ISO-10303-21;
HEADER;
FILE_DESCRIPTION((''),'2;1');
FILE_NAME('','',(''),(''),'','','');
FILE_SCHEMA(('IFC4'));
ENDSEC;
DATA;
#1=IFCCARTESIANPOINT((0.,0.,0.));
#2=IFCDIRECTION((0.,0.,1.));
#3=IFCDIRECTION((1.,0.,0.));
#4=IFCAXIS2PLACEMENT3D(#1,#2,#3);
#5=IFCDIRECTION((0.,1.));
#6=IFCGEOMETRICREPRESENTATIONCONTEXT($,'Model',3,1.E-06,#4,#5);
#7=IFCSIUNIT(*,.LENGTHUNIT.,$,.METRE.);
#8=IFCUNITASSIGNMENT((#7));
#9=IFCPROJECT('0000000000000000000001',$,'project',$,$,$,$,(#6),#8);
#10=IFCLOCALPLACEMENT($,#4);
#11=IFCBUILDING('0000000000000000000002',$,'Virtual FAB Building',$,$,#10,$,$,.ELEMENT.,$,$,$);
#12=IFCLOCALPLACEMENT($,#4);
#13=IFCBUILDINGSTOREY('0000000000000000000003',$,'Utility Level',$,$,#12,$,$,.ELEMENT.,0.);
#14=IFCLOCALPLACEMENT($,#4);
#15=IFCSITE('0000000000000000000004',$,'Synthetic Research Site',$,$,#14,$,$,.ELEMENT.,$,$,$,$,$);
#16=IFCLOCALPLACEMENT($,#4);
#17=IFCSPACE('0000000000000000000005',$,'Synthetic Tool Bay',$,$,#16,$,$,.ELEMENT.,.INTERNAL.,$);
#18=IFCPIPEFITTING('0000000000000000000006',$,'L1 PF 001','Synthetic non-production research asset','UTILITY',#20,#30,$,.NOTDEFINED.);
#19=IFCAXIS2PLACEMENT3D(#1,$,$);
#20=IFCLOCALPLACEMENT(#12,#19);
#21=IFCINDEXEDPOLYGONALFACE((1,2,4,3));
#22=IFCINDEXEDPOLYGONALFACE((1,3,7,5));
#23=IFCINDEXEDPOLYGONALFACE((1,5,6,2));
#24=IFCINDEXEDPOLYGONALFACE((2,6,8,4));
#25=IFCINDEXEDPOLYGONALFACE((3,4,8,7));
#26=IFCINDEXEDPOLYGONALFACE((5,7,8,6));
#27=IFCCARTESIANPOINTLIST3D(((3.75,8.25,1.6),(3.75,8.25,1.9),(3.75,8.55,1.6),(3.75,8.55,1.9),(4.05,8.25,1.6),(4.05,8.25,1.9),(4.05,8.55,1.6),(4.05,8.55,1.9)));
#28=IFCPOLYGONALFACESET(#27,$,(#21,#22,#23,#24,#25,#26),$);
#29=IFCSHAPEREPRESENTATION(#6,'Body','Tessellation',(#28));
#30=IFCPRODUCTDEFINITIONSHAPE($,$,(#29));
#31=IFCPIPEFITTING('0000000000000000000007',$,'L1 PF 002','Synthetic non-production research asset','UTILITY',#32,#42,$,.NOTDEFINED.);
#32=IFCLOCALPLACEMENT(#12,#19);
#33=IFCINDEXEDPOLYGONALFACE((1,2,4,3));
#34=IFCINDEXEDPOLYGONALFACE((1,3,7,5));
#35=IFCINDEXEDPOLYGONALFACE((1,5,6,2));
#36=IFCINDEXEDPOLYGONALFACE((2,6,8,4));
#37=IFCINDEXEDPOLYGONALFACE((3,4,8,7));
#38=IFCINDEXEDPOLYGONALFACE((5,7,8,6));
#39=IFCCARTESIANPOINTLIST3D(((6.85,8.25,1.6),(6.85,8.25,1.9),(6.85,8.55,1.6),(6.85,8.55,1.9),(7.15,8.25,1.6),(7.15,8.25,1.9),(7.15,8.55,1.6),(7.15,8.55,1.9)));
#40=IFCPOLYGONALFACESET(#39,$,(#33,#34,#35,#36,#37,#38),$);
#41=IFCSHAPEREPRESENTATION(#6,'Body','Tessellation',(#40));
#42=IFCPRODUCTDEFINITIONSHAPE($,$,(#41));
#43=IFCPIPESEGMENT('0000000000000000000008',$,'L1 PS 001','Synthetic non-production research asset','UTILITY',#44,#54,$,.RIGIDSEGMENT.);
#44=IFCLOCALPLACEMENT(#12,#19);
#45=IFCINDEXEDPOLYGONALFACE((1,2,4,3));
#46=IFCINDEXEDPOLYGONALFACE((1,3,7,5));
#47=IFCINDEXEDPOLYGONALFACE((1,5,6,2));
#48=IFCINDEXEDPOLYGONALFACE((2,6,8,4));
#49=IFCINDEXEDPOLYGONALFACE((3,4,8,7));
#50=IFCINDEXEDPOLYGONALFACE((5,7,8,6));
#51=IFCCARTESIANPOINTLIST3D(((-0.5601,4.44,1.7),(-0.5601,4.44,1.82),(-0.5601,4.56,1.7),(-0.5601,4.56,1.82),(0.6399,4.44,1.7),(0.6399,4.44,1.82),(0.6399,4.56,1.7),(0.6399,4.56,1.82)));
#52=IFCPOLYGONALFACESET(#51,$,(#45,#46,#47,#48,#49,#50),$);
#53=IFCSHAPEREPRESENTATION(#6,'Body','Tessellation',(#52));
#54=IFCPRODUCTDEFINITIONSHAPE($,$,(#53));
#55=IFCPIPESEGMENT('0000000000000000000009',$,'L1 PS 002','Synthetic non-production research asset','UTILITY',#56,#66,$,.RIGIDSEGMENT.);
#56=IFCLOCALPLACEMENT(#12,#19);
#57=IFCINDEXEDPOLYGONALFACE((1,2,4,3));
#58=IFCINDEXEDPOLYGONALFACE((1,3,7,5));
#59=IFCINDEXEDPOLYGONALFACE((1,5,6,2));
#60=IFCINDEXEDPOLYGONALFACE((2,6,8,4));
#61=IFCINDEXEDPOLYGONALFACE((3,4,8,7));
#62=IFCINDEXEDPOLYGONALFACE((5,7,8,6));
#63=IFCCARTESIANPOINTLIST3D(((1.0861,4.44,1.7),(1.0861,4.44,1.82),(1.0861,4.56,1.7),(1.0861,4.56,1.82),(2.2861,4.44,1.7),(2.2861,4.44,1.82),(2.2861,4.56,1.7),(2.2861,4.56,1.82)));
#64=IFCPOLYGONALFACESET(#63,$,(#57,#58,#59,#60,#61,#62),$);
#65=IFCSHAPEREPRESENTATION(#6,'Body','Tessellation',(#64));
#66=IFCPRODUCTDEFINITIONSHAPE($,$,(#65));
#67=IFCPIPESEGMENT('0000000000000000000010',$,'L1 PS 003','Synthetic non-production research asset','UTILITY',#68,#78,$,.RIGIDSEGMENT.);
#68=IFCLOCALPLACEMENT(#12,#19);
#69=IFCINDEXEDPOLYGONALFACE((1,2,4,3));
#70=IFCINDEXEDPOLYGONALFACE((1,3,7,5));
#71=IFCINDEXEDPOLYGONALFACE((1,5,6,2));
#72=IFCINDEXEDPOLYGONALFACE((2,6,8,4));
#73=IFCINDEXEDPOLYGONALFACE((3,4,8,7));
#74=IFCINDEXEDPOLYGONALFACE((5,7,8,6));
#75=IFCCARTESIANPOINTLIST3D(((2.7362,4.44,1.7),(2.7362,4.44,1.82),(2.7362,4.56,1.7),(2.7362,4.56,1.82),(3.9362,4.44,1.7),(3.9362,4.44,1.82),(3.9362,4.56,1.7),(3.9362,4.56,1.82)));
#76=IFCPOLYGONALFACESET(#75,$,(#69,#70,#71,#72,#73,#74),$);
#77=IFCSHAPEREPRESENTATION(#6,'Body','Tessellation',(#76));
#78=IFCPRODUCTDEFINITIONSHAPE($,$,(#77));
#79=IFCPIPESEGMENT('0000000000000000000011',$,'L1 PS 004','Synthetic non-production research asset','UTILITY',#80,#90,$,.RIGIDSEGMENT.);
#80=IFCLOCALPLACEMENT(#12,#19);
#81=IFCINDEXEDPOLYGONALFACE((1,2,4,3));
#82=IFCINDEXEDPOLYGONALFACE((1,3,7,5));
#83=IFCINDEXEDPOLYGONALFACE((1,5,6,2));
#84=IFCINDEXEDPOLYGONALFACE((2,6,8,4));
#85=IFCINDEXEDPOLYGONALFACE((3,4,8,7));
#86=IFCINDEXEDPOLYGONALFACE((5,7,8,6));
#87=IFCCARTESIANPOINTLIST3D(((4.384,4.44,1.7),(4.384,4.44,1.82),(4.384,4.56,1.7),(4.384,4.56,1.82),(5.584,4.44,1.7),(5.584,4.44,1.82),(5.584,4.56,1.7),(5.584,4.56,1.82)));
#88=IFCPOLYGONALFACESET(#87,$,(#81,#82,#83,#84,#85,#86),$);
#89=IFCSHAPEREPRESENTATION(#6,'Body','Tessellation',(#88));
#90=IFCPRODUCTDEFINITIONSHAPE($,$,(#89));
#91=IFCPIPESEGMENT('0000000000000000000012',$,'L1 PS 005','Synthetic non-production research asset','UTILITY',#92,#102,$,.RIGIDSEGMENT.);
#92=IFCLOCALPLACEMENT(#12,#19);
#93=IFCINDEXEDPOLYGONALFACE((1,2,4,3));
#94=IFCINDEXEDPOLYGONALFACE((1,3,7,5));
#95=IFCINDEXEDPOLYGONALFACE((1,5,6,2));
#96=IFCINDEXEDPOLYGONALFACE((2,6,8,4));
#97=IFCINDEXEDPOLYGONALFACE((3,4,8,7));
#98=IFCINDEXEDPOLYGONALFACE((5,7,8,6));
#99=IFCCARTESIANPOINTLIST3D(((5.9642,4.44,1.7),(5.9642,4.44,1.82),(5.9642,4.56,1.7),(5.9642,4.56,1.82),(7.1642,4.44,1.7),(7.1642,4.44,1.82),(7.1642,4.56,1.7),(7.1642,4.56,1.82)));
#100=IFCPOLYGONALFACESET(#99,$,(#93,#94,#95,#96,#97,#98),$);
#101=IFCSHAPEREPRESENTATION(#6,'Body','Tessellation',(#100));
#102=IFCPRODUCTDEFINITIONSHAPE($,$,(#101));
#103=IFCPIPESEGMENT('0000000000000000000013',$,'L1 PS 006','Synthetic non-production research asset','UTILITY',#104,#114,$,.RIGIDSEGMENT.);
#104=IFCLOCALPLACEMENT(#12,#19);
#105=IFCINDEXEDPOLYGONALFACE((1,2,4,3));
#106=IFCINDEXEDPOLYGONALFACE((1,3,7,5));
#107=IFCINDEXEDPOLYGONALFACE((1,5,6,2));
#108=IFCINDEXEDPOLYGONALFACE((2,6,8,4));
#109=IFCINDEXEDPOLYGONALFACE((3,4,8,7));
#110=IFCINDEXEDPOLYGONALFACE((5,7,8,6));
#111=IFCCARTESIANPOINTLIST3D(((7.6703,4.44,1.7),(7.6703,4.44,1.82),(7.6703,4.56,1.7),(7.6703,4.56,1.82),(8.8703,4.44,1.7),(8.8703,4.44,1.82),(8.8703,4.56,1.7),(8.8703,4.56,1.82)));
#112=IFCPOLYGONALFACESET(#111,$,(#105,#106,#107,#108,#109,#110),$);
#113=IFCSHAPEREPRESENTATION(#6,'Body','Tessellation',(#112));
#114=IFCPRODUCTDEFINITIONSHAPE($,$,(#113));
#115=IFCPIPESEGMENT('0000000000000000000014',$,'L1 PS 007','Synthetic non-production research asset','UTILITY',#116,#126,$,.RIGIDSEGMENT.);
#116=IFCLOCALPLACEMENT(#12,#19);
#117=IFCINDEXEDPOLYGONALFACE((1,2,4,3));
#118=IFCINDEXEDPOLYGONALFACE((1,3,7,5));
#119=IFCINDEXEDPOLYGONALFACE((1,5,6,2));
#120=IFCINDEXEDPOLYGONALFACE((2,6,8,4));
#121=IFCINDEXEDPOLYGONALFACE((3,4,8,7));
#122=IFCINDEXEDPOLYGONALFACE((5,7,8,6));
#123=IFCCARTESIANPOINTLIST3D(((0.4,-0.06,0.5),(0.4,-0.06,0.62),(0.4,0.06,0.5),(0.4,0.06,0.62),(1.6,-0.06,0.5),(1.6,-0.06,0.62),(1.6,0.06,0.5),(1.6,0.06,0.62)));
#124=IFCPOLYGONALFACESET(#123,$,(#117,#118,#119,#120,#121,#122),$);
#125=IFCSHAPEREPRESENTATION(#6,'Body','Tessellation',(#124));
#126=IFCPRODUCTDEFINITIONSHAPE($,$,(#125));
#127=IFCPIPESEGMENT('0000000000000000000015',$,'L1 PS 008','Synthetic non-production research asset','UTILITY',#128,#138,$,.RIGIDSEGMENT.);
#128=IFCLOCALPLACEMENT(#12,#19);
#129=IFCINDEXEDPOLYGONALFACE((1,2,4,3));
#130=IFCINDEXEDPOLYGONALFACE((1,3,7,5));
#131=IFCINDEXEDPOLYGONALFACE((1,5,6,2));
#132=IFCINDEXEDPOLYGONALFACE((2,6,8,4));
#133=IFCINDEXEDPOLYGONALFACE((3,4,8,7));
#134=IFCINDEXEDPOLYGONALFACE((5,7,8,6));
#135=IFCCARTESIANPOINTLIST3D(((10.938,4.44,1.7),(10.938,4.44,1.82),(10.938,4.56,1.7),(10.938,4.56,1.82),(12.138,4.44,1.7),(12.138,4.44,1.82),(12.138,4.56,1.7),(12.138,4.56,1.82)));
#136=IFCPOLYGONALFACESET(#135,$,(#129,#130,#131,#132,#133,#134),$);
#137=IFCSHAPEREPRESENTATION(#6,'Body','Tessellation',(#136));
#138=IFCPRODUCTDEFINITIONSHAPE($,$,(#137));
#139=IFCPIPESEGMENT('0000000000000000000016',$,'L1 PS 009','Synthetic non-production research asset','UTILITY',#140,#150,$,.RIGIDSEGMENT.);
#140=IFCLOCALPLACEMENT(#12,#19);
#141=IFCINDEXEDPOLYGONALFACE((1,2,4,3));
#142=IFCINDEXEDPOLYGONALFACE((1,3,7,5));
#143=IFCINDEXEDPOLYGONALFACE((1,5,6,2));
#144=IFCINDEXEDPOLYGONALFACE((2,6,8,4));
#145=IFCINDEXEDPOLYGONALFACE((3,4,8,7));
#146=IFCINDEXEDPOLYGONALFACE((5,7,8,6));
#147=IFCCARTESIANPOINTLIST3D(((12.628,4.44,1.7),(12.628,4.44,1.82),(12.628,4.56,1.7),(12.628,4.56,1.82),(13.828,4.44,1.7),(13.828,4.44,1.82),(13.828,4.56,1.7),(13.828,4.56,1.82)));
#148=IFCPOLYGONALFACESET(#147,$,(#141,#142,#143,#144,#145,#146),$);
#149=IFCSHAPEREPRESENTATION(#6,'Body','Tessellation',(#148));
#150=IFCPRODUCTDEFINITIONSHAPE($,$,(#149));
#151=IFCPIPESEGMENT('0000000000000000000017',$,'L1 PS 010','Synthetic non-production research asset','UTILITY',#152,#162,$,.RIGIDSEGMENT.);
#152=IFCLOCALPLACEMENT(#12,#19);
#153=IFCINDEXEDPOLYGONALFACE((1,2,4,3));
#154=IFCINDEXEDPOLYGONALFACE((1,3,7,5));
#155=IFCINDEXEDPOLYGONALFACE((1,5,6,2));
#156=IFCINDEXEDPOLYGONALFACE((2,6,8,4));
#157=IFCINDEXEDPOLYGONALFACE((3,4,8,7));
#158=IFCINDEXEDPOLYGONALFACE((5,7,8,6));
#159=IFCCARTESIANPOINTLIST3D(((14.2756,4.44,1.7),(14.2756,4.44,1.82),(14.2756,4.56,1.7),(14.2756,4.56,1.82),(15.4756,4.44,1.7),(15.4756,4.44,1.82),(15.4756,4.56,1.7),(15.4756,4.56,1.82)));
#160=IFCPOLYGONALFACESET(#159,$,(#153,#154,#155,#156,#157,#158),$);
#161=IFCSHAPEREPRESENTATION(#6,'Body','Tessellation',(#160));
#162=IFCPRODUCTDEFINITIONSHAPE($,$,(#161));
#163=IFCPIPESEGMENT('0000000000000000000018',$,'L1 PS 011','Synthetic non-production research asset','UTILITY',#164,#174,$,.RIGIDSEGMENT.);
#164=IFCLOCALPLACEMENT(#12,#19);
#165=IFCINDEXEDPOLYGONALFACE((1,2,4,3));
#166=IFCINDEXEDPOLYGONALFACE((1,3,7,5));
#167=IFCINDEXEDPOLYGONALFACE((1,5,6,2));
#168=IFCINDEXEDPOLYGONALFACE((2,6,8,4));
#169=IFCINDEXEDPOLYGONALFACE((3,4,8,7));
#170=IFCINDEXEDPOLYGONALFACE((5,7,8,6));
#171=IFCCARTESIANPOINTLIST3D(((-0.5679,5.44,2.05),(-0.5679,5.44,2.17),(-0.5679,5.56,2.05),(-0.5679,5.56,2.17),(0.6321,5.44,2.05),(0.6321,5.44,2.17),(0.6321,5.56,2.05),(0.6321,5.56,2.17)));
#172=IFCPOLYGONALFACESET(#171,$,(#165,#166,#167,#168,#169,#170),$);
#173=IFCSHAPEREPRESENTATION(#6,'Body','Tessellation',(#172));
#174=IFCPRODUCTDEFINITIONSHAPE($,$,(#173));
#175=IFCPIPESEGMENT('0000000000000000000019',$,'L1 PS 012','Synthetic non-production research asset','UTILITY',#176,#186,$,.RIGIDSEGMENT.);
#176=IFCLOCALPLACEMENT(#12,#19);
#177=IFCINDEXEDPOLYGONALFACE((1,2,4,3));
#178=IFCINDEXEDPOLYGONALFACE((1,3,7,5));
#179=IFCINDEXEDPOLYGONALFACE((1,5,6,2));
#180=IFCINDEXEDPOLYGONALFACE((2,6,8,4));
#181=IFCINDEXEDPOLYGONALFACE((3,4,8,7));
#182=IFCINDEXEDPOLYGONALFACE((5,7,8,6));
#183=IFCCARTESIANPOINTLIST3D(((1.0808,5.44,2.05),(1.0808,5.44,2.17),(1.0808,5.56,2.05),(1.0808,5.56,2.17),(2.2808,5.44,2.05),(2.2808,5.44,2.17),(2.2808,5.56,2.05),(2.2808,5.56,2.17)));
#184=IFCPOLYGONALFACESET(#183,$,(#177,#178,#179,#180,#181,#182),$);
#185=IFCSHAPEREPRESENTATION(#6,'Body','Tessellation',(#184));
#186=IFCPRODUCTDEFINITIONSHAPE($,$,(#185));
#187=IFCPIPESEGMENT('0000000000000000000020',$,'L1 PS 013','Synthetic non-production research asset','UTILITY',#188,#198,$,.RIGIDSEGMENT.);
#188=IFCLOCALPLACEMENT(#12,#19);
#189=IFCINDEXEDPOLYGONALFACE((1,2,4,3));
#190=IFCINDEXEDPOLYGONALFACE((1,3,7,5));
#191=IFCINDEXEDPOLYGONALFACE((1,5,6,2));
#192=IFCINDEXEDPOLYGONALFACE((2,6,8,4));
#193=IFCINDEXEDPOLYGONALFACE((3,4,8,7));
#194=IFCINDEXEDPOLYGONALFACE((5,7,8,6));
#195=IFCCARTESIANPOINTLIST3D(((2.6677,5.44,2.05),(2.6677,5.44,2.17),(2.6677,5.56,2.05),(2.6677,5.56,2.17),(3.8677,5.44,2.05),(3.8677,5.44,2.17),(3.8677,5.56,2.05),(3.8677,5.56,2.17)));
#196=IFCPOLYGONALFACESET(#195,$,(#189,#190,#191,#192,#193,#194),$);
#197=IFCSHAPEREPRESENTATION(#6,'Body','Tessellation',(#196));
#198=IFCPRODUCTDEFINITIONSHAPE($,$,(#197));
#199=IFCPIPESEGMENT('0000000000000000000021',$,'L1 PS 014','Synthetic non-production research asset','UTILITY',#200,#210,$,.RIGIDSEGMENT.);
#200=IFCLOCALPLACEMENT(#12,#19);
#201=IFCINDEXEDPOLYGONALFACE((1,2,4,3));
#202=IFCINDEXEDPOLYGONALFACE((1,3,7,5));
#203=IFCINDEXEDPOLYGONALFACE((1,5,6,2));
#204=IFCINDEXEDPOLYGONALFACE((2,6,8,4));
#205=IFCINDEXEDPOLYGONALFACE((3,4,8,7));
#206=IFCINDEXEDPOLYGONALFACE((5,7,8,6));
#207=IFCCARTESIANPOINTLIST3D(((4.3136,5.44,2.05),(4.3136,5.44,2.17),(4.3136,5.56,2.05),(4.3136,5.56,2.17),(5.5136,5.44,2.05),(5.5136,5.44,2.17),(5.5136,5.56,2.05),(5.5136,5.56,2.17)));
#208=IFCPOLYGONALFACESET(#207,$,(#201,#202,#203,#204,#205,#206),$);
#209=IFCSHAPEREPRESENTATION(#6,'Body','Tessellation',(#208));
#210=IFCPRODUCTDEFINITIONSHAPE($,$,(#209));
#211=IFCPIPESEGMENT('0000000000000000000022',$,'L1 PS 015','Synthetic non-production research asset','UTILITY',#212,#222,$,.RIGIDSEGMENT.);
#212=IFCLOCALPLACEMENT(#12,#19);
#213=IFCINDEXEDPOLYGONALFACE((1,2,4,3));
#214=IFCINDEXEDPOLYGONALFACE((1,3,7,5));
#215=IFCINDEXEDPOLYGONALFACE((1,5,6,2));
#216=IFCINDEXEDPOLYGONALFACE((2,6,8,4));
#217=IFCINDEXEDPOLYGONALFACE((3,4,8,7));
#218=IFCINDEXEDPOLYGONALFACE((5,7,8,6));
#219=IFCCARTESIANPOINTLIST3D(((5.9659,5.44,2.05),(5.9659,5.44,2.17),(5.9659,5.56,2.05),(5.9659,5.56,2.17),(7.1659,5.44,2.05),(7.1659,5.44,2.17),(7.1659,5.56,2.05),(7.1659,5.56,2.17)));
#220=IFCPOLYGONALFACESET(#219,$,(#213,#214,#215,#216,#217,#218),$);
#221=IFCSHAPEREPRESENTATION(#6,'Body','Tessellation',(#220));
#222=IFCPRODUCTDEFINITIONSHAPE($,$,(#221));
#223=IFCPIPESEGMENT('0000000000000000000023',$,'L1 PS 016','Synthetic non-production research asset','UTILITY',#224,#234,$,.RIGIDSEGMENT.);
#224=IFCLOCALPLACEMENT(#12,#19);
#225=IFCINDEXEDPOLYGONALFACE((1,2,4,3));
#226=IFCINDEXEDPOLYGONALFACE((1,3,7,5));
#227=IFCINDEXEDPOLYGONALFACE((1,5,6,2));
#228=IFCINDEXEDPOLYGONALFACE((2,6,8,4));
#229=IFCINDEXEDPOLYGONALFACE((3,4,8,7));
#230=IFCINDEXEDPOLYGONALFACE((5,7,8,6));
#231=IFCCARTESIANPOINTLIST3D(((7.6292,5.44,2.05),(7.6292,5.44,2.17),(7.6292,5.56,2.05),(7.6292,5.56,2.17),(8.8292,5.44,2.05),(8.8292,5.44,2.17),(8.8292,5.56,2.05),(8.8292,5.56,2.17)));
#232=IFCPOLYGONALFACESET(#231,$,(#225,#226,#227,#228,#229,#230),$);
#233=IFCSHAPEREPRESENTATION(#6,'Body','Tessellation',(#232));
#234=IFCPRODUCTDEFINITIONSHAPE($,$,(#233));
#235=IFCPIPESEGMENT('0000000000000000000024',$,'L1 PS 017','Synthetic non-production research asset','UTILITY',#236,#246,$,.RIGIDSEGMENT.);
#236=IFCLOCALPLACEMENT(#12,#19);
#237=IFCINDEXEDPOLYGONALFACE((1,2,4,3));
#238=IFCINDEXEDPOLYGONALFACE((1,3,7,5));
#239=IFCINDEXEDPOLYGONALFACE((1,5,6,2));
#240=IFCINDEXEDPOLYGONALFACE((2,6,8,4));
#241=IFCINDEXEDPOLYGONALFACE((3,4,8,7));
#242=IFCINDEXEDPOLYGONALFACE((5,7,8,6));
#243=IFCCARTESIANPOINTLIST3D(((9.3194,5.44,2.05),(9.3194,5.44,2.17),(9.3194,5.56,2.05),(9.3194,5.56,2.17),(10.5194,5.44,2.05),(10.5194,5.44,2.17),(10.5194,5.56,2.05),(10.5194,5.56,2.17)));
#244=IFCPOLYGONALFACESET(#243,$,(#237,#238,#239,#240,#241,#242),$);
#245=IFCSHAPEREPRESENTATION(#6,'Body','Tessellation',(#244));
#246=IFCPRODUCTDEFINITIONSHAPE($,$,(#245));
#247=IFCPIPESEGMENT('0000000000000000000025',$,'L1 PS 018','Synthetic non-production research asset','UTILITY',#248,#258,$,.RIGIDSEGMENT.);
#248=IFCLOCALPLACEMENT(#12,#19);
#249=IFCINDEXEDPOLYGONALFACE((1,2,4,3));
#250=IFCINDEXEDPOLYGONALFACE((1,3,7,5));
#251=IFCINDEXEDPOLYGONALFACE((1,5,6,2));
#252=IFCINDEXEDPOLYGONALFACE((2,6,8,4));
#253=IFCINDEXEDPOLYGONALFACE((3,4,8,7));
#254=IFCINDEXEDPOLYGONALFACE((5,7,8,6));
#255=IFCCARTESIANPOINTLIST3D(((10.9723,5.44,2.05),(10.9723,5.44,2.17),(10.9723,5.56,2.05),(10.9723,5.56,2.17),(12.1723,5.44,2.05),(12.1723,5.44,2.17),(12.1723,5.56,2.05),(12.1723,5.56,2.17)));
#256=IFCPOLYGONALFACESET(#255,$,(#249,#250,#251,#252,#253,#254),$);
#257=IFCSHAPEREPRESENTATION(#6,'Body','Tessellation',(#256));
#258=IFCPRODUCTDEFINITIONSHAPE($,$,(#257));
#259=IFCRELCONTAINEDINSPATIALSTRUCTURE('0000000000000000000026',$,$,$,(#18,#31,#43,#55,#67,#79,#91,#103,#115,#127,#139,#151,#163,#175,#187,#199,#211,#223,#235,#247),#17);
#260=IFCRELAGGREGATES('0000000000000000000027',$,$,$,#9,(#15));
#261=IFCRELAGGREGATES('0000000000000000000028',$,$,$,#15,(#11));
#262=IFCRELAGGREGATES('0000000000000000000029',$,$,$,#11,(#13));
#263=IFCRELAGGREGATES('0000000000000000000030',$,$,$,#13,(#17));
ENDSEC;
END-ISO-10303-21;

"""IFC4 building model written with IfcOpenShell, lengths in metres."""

from ifc_helpers import new_model, si_unit, direction, frame, origin_with_axes, origin_2d_with_axis, place, context, project, spatial, rectangle, extrude, element, save


model = new_model("IFC4")

# Units and contexts
model_context = context("Model", 3, precision=1e-06, world=origin_with_axes(), true_north=direction((0.0, 1.0)))
ifc_project = project(units=[si_unit("LENGTHUNIT", "METRE")], contexts=[model_context])

# Site, building, storey, space
site_placement = place(None, origin_with_axes())
site = spatial("IfcSite", under=ifc_project, at=site_placement, Name="Synthetic Research Site", CompositionType="ELEMENT")
building_placement = place(None, origin_with_axes())
building = spatial("IfcBuilding", under=site, at=building_placement, Name="Virtual FAB Building", CompositionType="ELEMENT")
storey_placement = place(None, origin_with_axes())
storey = spatial("IfcBuildingStorey", under=building, at=storey_placement, Name="Utility Level", CompositionType="ELEMENT", Elevation=0.0)
space_placement = place(None, origin_with_axes())
space = spatial("IfcSpace", under=storey, at=space_placement, Name="Synthetic Tool Bay", CompositionType="ELEMENT", PredefinedType="INTERNAL")

# Pipe fittings
for number, where, z_axis, x_axis, name in (
    (1, (3.9, 8.4, 1.6), (0.0, 0.0, 1.0), (1.0, 0.0, 0.0), "L1 PF 001"),
    (2, (7.0, 8.4, 1.6), (0.0, 0.0, 1.0), (1.0, 0.0, 0.0), "L1 PF 002"),
):
    element("IfcPipeFitting", number, at=place(None, frame(where, z_axis=z_axis, x_axis=x_axis)), inside=space, Name=name, Description="Synthetic non-production research asset", ObjectType="UTILITY", PredefinedType="NOTDEFINED", context=model_context, shape_type="SweptSolid", body=[
        extrude(rectangle(XDim=0.3, YDim=0.3, at=origin_2d_with_axis()), origin_with_axes(), (0.0, 0.0, 1.0), 0.3),
    ])

# Pipe segments
for number, where, z_axis, x_axis, name in (
    (3, (0.0399, 4.5, 1.7), (0.0, 0.0, 1.0), (1.0, 0.0, 0.0), "L1 PS 001"),
    (4, (1.6861, 4.5, 1.7), (0.0, 0.0, 1.0), (1.0, 0.0, 0.0), "L1 PS 002"),
    (5, (3.3362, 4.5, 1.7), (0.0, 0.0, 1.0), (1.0, 0.0, 0.0), "L1 PS 003"),
    (6, (4.984, 4.5, 1.7), (0.0, 0.0, 1.0), (1.0, 0.0, 0.0), "L1 PS 004"),
    (7, (6.5642, 4.5, 1.7), (0.0, 0.0, 1.0), (1.0, 0.0, 0.0), "L1 PS 005"),
    (8, (8.2703, 4.5, 1.7), (0.0, 0.0, 1.0), (1.0, 0.0, 0.0), "L1 PS 006"),
    (9, (1.0, 0.0, 0.5), (0.0, 0.0, 1.0), (1.0, 0.0, 0.0), "L1 PS 007"),
    (10, (11.538, 4.5, 1.7), (0.0, 0.0, 1.0), (1.0, 0.0, 0.0), "L1 PS 008"),
    (11, (13.228, 4.5, 1.7), (0.0, 0.0, 1.0), (1.0, 0.0, 0.0), "L1 PS 009"),
    (12, (14.8756, 4.5, 1.7), (0.0, 0.0, 1.0), (1.0, 0.0, 0.0), "L1 PS 010"),
    (13, (0.0321, 5.5, 2.05), (0.0, 0.0, 1.0), (1.0, 0.0, 0.0), "L1 PS 011"),
    (14, (1.6808, 5.5, 2.05), (0.0, 0.0, 1.0), (1.0, 0.0, 0.0), "L1 PS 012"),
    (15, (3.2677, 5.5, 2.05), (0.0, 0.0, 1.0), (1.0, 0.0, 0.0), "L1 PS 013"),
    (16, (4.9136, 5.5, 2.05), (0.0, 0.0, 1.0), (1.0, 0.0, 0.0), "L1 PS 014"),
    (17, (6.5659, 5.5, 2.05), (0.0, 0.0, 1.0), (1.0, 0.0, 0.0), "L1 PS 015"),
    (18, (8.2292, 5.5, 2.05), (0.0, 0.0, 1.0), (1.0, 0.0, 0.0), "L1 PS 016"),
    (19, (9.9194, 5.5, 2.05), (0.0, 0.0, 1.0), (1.0, 0.0, 0.0), "L1 PS 017"),
    (20, (11.5723, 5.5, 2.05), (0.0, 0.0, 1.0), (1.0, 0.0, 0.0), "L1 PS 018"),
):
    element("IfcPipeSegment", number, at=place(None, frame(where, z_axis=z_axis, x_axis=x_axis)), inside=space, Name=name, Description="Synthetic non-production research asset", ObjectType="UTILITY", PredefinedType="RIGIDSEGMENT", context=model_context, shape_type="SweptSolid", body=[
        extrude(rectangle(XDim=1.2, YDim=0.12, at=origin_2d_with_axis()), origin_with_axes(), (0.0, 0.0, 1.0), 0.12),
    ])

save(model, "model.ifc")
